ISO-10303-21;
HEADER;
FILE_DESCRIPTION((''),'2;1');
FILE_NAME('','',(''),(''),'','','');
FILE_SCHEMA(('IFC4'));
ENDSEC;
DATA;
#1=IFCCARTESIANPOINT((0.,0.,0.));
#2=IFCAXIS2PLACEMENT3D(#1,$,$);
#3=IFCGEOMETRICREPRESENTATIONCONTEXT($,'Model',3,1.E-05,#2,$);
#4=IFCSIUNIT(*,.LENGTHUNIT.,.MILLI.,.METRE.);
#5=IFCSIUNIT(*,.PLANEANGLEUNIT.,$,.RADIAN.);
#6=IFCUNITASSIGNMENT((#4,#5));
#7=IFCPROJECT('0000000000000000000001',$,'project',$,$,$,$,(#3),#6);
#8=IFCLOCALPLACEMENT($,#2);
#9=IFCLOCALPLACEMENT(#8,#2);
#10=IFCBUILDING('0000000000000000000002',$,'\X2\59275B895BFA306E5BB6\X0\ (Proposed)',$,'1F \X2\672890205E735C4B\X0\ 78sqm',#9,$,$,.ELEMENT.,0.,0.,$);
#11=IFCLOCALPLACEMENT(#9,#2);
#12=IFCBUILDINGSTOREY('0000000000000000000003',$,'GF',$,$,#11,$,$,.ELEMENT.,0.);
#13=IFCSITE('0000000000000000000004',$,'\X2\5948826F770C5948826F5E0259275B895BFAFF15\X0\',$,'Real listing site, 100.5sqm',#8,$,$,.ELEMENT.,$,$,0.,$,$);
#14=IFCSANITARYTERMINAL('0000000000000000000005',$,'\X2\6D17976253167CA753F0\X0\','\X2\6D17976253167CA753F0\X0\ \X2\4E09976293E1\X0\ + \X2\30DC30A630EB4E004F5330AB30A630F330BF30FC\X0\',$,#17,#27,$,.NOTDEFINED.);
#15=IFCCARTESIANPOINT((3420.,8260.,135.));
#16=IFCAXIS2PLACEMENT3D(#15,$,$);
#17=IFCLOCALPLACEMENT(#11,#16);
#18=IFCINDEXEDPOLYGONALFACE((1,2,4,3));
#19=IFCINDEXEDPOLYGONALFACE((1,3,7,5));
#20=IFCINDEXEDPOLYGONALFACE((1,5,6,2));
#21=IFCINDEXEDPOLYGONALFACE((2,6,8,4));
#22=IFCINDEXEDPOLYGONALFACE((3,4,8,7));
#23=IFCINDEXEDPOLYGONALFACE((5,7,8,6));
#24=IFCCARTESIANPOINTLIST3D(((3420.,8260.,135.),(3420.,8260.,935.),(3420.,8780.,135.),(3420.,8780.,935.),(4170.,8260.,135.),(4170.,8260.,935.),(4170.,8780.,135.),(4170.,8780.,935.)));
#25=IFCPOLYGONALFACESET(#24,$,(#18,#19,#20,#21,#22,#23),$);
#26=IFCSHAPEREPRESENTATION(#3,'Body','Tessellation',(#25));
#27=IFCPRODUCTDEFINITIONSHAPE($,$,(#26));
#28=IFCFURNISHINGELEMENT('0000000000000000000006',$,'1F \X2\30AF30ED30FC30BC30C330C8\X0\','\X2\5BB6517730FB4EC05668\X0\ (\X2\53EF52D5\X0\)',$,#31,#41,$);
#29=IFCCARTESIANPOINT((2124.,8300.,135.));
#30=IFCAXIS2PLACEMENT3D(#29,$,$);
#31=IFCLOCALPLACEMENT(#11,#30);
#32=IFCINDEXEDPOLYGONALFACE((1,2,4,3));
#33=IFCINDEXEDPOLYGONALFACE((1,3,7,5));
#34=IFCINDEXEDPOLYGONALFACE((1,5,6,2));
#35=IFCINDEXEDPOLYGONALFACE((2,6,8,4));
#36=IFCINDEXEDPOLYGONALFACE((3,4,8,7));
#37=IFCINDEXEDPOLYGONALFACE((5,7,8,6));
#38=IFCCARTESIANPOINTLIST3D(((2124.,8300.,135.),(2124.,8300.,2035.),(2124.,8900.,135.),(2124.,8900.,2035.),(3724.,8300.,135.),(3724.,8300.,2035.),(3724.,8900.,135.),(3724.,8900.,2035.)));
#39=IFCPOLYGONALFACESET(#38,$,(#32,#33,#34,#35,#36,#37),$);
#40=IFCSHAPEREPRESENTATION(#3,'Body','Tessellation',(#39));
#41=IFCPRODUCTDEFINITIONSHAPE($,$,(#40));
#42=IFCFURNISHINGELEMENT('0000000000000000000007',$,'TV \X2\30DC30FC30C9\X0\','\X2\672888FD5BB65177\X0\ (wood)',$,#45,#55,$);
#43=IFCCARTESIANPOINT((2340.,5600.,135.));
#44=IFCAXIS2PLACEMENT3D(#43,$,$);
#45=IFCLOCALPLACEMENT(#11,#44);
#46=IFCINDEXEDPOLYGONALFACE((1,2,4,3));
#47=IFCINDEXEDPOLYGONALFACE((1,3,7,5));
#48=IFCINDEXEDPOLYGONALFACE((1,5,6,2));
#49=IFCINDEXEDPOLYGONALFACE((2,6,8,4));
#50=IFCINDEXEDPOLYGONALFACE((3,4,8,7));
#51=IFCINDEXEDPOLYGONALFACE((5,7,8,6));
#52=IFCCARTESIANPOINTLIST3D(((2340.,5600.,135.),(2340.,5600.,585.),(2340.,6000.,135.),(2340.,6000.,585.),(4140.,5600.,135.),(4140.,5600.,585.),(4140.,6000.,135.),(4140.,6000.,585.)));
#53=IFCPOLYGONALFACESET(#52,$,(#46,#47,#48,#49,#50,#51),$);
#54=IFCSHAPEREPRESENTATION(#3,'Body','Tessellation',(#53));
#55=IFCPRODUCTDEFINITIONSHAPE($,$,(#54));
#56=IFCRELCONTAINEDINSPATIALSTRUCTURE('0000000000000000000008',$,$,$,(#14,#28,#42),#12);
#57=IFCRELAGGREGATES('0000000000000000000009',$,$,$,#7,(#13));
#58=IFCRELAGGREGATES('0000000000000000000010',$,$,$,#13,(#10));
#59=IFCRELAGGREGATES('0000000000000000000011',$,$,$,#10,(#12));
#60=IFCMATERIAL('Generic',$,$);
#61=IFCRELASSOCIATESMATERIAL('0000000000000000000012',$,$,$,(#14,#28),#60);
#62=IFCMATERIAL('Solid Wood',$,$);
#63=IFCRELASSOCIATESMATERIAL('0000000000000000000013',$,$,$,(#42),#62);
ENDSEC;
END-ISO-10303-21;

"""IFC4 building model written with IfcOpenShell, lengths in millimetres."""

from ifc_helpers import new_model, si_unit, frame, frame_2d, origin, place, context, project, spatial, rectangle, extrude, material, element, save


model = new_model("IFC4")

# Units and contexts
model_context = context("Model", 3, precision=1e-05, world=origin())
ifc_project = project(units=[si_unit("LENGTHUNIT", "METRE", prefix="MILLI"), si_unit("PLANEANGLEUNIT", "RADIAN")], contexts=[model_context])

# Site, building, storey
site_placement = place(None, origin())
site = spatial("IfcSite", under=ifc_project, at=site_placement, Name="奈良県奈良市大安寺５", ObjectType="Real listing site, 100.5sqm", CompositionType="ELEMENT", RefElevation=0.0)
building_placement = place(site_placement, origin())
building = spatial("IfcBuilding", under=site, at=building_placement, Name="大安寺の家 (Proposed)", ObjectType="1F 木造平屋 78sqm", CompositionType="ELEMENT", ElevationOfRefHeight=0.0, ElevationOfTerrain=0.0)
storey_placement = place(building_placement, origin())
storey = spatial("IfcBuildingStorey", under=building, at=storey_placement, Name="GF", CompositionType="ELEMENT", Elevation=0.0)

# Shared definitions
ifc_material_1 = material(Name="Solid Wood")

# Shared definitions
ifc_material_2 = material(Name="Generic")

# Sanitary terminal
sanitary_terminal_1_placement = place(storey_placement, frame((3420.0, 8260.0, 135.0)))
element("IfcSanitaryTerminal", 1, at=sanitary_terminal_1_placement, inside=storey, material=ifc_material_2, Name="洗面化粧台", Description="洗面化粧台 三面鏡 + ボウル一体カウンター", PredefinedType="NOTDEFINED", context=model_context, shape_type="SweptSolid", body=[
    extrude(rectangle(XDim=750.0, YDim=520.0, at=frame_2d((375.0, 260.0))), frame((3420.0, 8260.0, 135.0)), (0.0, 0.0, 1.0), 800.0),
])

# Furnishing elements
furnishing_1_placement = place(storey_placement, frame((2124.0, 8300.0, 135.0)))
element("IfcFurnishingElement", 2, at=furnishing_1_placement, inside=storey, material=ifc_material_2, Name="1F クローゼット", Description="家具・什器 (可動)", context=model_context, shape_type="SweptSolid", body=[
    extrude(rectangle(XDim=1600.0, YDim=600.0, at=frame_2d((800.0, 300.0))), frame((2124.0, 8300.0, 135.0)), (0.0, 0.0, 1.0), 1900.0),
])
furnishing_2_placement = place(storey_placement, frame((2340.0, 5600.0, 135.0)))
element("IfcFurnishingElement", 3, at=furnishing_2_placement, inside=storey, material=ifc_material_1, Name="TV ボード", Description="木製家具 (wood)", context=model_context, shape_type="SweptSolid", body=[
    extrude(rectangle(XDim=1800.0, YDim=400.0, at=frame_2d((900.0, 200.0))), frame((2340.0, 5600.0, 135.0)), (0.0, 0.0, 1.0), 450.0),
])

save(model, "model.ifc")
